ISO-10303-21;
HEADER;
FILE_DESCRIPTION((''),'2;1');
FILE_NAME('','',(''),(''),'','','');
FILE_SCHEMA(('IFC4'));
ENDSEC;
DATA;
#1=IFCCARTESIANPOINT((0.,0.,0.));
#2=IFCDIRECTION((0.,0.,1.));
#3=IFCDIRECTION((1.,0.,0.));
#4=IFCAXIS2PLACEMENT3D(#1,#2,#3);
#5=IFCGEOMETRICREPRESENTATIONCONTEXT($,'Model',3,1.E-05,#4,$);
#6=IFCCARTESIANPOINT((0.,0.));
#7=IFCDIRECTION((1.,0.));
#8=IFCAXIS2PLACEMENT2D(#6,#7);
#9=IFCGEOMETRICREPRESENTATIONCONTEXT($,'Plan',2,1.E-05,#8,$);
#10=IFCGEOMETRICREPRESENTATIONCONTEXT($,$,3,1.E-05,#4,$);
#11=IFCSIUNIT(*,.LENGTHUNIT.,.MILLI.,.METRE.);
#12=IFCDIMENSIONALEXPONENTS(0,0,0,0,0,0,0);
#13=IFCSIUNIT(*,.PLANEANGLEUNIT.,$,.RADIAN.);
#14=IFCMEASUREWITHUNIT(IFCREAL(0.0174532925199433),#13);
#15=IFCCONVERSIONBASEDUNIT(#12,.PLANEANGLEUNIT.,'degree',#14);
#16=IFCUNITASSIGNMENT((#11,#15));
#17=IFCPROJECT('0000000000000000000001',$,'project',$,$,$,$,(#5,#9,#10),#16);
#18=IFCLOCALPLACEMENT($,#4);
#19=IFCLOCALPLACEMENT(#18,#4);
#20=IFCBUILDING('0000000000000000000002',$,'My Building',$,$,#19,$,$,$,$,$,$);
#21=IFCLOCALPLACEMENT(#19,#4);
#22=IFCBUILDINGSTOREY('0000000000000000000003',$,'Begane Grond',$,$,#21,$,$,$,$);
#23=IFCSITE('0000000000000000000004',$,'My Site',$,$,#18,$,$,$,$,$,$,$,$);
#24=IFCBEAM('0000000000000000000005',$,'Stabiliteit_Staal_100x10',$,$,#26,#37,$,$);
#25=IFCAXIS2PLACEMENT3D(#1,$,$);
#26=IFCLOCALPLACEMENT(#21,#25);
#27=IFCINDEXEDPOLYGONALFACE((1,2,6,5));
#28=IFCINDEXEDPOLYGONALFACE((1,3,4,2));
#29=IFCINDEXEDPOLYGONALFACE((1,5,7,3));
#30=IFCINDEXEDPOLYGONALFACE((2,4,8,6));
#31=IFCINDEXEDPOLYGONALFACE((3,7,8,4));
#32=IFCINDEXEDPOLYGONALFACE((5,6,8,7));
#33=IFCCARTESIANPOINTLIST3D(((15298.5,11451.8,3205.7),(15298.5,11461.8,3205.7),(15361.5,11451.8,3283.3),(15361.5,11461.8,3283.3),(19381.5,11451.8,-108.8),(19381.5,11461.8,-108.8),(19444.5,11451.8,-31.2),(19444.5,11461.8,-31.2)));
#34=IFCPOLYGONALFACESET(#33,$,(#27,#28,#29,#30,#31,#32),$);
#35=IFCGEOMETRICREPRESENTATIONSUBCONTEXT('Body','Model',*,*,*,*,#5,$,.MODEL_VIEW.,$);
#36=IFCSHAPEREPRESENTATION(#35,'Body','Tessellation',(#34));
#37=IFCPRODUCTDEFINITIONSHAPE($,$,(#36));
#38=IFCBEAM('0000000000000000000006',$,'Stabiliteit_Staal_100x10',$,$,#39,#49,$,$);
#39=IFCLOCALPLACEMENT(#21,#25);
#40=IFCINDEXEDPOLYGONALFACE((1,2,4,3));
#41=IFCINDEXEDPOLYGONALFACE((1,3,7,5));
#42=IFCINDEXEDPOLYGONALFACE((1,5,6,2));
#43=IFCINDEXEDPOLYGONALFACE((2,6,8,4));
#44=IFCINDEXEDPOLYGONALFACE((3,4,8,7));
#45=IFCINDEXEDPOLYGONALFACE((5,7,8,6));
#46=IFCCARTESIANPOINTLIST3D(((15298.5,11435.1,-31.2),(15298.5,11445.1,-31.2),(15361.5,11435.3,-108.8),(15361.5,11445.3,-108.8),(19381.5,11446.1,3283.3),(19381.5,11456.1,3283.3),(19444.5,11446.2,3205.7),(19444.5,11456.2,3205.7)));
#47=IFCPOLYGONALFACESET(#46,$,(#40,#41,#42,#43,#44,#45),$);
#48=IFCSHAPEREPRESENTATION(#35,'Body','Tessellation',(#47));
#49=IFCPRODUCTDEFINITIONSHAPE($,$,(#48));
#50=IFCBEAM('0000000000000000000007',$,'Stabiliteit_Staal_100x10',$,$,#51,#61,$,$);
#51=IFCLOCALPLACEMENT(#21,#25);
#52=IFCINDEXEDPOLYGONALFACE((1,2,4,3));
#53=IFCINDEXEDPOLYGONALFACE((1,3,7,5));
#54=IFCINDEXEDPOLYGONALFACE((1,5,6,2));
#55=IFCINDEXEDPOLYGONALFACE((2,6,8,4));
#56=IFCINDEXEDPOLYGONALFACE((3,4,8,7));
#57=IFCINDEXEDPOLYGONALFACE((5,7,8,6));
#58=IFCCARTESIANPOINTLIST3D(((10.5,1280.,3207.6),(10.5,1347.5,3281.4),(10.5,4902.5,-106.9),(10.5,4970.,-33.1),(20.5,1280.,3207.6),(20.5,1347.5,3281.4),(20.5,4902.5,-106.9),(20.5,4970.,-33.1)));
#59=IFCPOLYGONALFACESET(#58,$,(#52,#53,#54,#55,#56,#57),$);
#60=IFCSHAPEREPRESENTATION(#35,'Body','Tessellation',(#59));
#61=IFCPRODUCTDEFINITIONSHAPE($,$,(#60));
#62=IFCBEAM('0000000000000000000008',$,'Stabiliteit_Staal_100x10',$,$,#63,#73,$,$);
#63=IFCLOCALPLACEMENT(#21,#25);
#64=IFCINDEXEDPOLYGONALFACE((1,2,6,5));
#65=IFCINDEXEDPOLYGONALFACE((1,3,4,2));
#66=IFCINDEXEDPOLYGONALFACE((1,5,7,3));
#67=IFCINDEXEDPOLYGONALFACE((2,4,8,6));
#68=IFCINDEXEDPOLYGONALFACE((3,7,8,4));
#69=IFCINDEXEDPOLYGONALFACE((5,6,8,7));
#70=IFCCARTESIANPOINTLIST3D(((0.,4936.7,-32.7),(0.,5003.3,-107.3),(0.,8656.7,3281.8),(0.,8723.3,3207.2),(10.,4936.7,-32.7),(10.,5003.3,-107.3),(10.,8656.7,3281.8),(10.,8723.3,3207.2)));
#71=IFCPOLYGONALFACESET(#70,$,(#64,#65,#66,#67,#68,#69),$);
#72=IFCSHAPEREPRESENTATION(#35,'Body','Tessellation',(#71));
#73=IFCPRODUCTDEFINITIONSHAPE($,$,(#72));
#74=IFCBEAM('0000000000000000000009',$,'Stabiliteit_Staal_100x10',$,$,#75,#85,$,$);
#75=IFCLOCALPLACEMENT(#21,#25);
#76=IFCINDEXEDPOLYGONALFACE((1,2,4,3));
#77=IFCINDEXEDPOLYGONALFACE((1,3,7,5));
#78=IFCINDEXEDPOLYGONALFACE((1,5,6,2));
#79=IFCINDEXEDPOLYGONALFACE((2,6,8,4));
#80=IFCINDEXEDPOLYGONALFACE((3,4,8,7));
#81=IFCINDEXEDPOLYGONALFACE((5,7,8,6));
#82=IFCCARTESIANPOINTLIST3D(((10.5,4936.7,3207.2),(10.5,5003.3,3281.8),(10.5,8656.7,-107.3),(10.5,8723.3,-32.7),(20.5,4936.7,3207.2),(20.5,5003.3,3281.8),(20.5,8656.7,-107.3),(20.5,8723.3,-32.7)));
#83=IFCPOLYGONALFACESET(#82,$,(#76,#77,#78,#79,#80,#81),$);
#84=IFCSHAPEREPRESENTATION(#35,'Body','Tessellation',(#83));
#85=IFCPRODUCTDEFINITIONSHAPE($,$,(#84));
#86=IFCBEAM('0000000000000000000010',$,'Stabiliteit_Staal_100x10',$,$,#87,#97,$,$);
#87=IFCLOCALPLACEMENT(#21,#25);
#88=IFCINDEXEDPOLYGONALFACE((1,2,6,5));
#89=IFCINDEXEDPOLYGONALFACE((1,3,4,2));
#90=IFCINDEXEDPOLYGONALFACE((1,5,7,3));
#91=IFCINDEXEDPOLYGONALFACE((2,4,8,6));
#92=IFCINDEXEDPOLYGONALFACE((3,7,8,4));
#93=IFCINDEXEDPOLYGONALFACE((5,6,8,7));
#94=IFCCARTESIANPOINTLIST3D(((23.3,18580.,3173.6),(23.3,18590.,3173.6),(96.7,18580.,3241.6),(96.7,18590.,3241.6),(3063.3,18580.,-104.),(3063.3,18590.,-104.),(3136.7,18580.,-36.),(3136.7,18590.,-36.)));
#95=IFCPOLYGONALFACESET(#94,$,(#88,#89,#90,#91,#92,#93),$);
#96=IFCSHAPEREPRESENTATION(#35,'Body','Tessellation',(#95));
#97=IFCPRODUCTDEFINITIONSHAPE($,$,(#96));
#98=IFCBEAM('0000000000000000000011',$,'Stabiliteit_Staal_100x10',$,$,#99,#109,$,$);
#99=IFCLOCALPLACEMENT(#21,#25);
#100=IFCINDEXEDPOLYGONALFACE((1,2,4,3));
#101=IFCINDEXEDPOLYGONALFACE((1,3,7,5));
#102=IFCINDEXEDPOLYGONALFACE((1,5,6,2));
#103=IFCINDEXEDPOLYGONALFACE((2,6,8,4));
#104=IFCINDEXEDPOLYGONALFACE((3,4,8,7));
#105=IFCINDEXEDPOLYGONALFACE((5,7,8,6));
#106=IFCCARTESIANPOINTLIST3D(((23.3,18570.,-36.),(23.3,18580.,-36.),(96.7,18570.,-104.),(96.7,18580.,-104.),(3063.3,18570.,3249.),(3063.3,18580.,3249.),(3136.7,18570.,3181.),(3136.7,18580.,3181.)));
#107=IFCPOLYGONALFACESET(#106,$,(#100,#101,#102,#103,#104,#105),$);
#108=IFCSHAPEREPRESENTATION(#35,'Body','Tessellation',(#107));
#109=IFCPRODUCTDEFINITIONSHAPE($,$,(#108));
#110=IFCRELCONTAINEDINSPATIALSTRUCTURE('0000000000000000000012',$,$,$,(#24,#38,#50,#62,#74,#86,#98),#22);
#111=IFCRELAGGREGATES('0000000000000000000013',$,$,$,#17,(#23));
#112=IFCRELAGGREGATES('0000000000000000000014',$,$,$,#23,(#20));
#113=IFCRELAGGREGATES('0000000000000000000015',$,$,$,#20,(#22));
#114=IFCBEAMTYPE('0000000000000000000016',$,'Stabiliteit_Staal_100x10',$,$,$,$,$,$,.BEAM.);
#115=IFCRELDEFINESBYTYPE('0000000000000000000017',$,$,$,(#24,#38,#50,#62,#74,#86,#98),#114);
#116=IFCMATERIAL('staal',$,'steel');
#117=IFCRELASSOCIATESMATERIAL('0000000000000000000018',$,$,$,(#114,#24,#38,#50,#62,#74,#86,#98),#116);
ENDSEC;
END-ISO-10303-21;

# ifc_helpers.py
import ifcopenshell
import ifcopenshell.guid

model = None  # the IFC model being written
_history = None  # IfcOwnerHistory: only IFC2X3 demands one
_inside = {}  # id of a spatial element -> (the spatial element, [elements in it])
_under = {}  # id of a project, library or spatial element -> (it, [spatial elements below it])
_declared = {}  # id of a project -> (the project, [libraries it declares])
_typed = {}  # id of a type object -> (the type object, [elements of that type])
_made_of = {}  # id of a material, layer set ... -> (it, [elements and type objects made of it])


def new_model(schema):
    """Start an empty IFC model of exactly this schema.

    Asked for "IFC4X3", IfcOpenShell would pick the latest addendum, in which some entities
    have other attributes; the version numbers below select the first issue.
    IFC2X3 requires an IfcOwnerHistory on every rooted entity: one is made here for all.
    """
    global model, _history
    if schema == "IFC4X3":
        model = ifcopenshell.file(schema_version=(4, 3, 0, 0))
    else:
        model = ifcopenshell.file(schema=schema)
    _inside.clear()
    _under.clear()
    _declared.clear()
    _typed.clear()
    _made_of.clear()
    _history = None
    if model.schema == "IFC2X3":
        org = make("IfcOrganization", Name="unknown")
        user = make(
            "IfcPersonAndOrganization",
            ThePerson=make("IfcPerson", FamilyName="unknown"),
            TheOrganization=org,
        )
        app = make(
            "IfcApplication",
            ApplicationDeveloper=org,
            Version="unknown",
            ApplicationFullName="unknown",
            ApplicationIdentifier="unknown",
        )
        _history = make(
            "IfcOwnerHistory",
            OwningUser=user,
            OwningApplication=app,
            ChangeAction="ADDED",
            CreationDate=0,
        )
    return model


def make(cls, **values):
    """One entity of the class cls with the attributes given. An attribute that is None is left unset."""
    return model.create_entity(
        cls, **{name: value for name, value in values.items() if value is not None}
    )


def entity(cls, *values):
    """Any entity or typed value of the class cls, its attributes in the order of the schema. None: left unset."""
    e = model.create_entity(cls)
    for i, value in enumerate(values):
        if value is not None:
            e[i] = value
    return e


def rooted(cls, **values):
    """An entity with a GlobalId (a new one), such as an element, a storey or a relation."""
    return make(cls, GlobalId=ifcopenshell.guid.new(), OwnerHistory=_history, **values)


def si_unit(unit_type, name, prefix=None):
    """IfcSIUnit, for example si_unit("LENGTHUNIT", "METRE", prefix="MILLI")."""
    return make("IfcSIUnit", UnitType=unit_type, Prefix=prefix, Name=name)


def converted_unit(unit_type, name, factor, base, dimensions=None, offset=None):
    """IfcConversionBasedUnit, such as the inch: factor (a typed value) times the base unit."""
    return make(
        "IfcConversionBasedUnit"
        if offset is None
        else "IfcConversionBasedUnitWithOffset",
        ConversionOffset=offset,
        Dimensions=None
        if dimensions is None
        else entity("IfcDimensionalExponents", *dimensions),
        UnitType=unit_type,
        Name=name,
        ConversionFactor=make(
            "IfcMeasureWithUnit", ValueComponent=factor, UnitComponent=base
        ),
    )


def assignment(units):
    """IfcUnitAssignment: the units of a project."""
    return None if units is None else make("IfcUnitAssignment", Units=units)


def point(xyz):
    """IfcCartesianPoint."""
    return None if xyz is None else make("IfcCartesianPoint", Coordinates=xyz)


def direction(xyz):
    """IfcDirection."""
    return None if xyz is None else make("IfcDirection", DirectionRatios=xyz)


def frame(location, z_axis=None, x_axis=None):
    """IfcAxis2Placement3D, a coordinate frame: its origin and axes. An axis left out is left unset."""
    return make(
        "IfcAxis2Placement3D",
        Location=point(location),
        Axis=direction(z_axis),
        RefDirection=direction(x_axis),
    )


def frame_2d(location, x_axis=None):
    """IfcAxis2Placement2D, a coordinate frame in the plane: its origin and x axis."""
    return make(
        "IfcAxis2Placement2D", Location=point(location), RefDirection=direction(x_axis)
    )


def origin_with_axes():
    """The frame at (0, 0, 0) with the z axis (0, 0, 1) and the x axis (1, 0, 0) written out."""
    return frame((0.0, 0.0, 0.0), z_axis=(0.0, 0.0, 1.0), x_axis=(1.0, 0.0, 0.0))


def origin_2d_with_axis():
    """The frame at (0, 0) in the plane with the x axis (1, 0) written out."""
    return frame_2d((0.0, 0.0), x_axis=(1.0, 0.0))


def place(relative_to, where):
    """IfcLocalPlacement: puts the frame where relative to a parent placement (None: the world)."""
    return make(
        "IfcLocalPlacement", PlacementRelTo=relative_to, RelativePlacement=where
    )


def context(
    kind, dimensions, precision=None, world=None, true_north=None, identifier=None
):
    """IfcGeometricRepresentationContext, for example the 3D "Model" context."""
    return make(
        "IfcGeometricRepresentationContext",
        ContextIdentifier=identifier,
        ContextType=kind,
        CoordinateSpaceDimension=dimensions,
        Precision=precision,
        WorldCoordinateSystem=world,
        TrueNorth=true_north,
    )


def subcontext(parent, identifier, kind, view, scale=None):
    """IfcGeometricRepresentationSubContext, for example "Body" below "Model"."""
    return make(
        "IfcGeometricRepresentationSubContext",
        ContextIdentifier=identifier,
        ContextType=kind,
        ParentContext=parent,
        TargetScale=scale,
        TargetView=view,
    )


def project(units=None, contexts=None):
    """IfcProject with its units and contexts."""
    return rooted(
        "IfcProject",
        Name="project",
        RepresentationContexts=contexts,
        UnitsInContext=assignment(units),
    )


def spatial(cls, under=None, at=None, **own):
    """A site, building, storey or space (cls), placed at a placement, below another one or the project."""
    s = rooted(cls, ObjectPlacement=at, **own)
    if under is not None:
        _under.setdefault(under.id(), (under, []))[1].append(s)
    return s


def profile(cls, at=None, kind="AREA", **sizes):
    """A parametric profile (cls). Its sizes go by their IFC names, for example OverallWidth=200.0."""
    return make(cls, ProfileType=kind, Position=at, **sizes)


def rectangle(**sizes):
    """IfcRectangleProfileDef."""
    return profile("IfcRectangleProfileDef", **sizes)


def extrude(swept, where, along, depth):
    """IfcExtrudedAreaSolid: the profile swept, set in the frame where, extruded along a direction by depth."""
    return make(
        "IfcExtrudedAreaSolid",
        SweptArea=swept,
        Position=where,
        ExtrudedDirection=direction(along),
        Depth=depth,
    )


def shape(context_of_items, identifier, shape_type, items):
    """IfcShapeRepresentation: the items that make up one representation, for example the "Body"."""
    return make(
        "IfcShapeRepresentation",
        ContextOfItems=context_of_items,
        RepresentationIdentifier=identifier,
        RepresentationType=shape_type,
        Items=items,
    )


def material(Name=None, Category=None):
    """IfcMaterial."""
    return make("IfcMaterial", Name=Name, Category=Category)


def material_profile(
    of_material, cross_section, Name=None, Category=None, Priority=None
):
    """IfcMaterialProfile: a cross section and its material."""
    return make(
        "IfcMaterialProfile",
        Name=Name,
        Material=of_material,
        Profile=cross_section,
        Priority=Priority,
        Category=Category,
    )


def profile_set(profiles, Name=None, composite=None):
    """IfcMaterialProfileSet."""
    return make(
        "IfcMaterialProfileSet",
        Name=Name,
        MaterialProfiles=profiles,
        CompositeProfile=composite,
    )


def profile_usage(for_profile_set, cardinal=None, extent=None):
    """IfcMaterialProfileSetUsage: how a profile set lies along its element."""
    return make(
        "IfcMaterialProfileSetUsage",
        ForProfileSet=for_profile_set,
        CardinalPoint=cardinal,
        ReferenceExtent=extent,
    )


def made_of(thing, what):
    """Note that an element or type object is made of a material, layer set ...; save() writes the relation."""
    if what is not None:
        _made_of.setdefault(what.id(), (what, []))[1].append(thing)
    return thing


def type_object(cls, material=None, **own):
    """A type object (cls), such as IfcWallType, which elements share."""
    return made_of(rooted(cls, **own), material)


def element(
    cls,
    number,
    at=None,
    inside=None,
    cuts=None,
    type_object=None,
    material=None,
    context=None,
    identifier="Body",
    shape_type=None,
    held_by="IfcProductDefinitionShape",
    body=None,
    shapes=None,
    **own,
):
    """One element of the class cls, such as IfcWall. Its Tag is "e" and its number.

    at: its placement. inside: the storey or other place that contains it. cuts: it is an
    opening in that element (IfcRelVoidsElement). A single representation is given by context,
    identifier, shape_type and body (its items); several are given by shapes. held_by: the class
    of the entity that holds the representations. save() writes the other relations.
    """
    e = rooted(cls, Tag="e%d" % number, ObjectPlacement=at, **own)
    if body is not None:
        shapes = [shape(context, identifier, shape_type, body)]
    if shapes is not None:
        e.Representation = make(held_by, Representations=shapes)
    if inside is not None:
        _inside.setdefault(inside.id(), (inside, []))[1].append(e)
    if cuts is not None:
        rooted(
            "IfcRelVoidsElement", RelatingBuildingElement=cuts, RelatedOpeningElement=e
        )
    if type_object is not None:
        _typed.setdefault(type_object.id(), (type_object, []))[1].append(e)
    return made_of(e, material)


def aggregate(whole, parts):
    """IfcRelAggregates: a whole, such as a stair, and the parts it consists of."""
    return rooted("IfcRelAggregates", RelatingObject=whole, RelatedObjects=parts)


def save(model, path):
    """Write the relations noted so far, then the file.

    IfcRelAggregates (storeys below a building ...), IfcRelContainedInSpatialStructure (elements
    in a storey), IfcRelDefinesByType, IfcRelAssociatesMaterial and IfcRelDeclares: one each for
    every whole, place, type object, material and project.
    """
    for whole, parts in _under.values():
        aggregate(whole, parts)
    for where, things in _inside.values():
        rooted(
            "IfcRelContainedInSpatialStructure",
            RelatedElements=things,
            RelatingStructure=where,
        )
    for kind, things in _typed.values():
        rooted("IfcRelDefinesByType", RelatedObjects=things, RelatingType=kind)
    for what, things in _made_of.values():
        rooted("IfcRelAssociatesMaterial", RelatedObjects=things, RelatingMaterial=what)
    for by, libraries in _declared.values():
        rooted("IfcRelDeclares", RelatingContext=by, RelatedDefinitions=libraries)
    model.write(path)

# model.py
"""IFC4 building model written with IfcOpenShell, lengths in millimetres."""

from ifc_helpers import new_model, entity, si_unit, converted_unit, frame, origin_with_axes, origin_2d_with_axis, place, context, subcontext, project, spatial, rectangle, extrude, material, material_profile, profile_set, profile_usage, type_object, element, save


model = new_model("IFC4")

# Units and contexts
model_context = context("Model", 3, precision=1e-05, world=origin_with_axes())
plan_context = context("Plan", 2, precision=1e-05, world=origin_2d_with_axis())
context_of_model = context(None, 3, precision=1e-05, world=origin_with_axes())
body_context = subcontext(model_context, "Body", "Model", "MODEL_VIEW")
ifc_project = project(units=[si_unit("LENGTHUNIT", "METRE", prefix="MILLI"), converted_unit("PLANEANGLEUNIT", "degree", entity("IfcReal", 0.0174532925199433), si_unit("PLANEANGLEUNIT", "RADIAN"), dimensions=[0, 0, 0, 0, 0, 0, 0])], contexts=[model_context, plan_context, context_of_model])

# Site, building, storey
site_placement = place(None, origin_with_axes())
site = spatial("IfcSite", under=ifc_project, at=site_placement, Name="My Site")
building_placement = place(site_placement, origin_with_axes())
building = spatial("IfcBuilding", under=site, at=building_placement, Name="My Building")
storey_placement = place(building_placement, origin_with_axes())
storey = spatial("IfcBuildingStorey", under=building, at=storey_placement, Name="Begane Grond")

# Shared definitions
ifc_material = material(Name="staal", Category="steel")

# Beams
ifc_material_profile_1 = material_profile(ifc_material, rectangle(XDim=10.0, YDim=100.0, kind="CURVE"))
ifc_profile_set_1 = profile_set([ifc_material_profile_1])
beam_type = type_object("IfcBeamType", Name="Stabiliteit_Staal_100x10", PredefinedType="BEAM", material=ifc_profile_set_1)
ifc_profile_usage_1 = profile_usage(ifc_profile_set_1, cardinal=5)
beam_1_placement = place(storey_placement, frame((19413.0, 11456.8, -70.0), z_axis=(-0.776387, 0.0, 0.630256), x_axis=(0.0, -1.0, 0.0)))
element("IfcBeam", 1, at=beam_1_placement, inside=storey, type_object=beam_type, material=ifc_profile_usage_1, Name="Stabiliteit_Staal_100x10", context=body_context, shape_type="SweptSolid", body=[
    extrude(rectangle(XDim=10.0, YDim=100.0, kind="CURVE"), origin_with_axes(), (0.0, 0.0, 1.0), 5259.0),
])
ifc_profile_usage_2 = profile_usage(ifc_profile_set_1, cardinal=5)
beam_2_placement = place(storey_placement, frame((15330.0, 11440.2, -70.0), z_axis=(0.776386, 0.002089, 0.630255), x_axis=(-0.002691, 0.999996, 0.0)))
element("IfcBeam", 2, at=beam_2_placement, inside=storey, type_object=beam_type, material=ifc_profile_usage_2, Name="Stabiliteit_Staal_100x10", context=body_context, shape_type="SweptSolid", body=[
    extrude(rectangle(XDim=10.0, YDim=100.0, kind="CURVE"), origin_with_axes(), (0.0, 0.0, 1.0), 5259.0),
])
ifc_profile_usage_3 = profile_usage(ifc_profile_set_1, cardinal=5)
beam_3_placement = place(storey_placement, frame((15.5, 4936.3, -70.0), z_axis=(0.0, -0.737776, 0.675046), x_axis=(1.0, 0.0, 0.0)))
element("IfcBeam", 3, at=beam_3_placement, inside=storey, type_object=beam_type, material=ifc_profile_usage_3, Name="Stabiliteit_Staal_100x10", context=body_context, shape_type="SweptSolid", body=[
    extrude(rectangle(XDim=10.0, YDim=100.0, kind="CURVE"), origin_with_axes(), (0.0, 0.0, 1.0), 4910.0),
])
ifc_profile_usage_4 = profile_usage(ifc_profile_set_1, cardinal=5)
beam_4_placement = place(storey_placement, frame((5.0, 4970.0, -70.0), z_axis=(0.0, 0.746628, 0.665242), x_axis=(-1.0, 0.0, 0.0)))
element("IfcBeam", 4, at=beam_4_placement, inside=storey, type_object=beam_type, material=ifc_profile_usage_4, Name="Stabiliteit_Staal_100x10", context=body_context, shape_type="SweptSolid", body=[
    extrude(rectangle(XDim=10.0, YDim=100.0, kind="CURVE"), origin_with_axes(), (0.0, 0.0, 1.0), 4982.4),
])
ifc_profile_usage_5 = profile_usage(ifc_profile_set_1, cardinal=5)
beam_5_placement = place(storey_placement, frame((15.5, 8690.0, -70.0), z_axis=(0.0, -0.746628, 0.665242), x_axis=(1.0, 0.0, 0.0)))
element("IfcBeam", 5, at=beam_5_placement, inside=storey, type_object=beam_type, material=ifc_profile_usage_5, Name="Stabiliteit_Staal_100x10", context=body_context, shape_type="SweptSolid", body=[
    extrude(rectangle(XDim=10.0, YDim=100.0, kind="CURVE"), origin_with_axes(), (0.0, 0.0, 1.0), 4982.4),
])
ifc_profile_usage_6 = profile_usage(ifc_profile_set_1, cardinal=5)
beam_6_placement = place(storey_placement, frame((3100.0, 18585.0, -70.0), z_axis=(-0.680031, 0.0, 0.733183), x_axis=(0.0, -1.0, 0.0)))
element("IfcBeam", 6, at=beam_6_placement, inside=storey, type_object=beam_type, material=ifc_profile_usage_6, Name="Stabiliteit_Staal_100x10", context=body_context, shape_type="SweptSolid", body=[
    extrude(rectangle(XDim=10.0, YDim=100.0, kind="CURVE"), origin_with_axes(), (0.0, 0.0, 1.0), 4470.4),
])
ifc_profile_usage_7 = profile_usage(ifc_profile_set_1, cardinal=5)
beam_7_placement = place(storey_placement, frame((60.0, 18575.0, -70.0), z_axis=(0.679207, 0.0, 0.733946), x_axis=(0.0, 1.0, 0.0)))
element("IfcBeam", 7, at=beam_7_placement, inside=storey, type_object=beam_type, material=ifc_profile_usage_7, Name="Stabiliteit_Staal_100x10", context=body_context, shape_type="SweptSolid", body=[
    extrude(rectangle(XDim=10.0, YDim=100.0, kind="CURVE"), origin_with_axes(), (0.0, 0.0, 1.0), 4475.8),
])

save(model, "model.ifc")
